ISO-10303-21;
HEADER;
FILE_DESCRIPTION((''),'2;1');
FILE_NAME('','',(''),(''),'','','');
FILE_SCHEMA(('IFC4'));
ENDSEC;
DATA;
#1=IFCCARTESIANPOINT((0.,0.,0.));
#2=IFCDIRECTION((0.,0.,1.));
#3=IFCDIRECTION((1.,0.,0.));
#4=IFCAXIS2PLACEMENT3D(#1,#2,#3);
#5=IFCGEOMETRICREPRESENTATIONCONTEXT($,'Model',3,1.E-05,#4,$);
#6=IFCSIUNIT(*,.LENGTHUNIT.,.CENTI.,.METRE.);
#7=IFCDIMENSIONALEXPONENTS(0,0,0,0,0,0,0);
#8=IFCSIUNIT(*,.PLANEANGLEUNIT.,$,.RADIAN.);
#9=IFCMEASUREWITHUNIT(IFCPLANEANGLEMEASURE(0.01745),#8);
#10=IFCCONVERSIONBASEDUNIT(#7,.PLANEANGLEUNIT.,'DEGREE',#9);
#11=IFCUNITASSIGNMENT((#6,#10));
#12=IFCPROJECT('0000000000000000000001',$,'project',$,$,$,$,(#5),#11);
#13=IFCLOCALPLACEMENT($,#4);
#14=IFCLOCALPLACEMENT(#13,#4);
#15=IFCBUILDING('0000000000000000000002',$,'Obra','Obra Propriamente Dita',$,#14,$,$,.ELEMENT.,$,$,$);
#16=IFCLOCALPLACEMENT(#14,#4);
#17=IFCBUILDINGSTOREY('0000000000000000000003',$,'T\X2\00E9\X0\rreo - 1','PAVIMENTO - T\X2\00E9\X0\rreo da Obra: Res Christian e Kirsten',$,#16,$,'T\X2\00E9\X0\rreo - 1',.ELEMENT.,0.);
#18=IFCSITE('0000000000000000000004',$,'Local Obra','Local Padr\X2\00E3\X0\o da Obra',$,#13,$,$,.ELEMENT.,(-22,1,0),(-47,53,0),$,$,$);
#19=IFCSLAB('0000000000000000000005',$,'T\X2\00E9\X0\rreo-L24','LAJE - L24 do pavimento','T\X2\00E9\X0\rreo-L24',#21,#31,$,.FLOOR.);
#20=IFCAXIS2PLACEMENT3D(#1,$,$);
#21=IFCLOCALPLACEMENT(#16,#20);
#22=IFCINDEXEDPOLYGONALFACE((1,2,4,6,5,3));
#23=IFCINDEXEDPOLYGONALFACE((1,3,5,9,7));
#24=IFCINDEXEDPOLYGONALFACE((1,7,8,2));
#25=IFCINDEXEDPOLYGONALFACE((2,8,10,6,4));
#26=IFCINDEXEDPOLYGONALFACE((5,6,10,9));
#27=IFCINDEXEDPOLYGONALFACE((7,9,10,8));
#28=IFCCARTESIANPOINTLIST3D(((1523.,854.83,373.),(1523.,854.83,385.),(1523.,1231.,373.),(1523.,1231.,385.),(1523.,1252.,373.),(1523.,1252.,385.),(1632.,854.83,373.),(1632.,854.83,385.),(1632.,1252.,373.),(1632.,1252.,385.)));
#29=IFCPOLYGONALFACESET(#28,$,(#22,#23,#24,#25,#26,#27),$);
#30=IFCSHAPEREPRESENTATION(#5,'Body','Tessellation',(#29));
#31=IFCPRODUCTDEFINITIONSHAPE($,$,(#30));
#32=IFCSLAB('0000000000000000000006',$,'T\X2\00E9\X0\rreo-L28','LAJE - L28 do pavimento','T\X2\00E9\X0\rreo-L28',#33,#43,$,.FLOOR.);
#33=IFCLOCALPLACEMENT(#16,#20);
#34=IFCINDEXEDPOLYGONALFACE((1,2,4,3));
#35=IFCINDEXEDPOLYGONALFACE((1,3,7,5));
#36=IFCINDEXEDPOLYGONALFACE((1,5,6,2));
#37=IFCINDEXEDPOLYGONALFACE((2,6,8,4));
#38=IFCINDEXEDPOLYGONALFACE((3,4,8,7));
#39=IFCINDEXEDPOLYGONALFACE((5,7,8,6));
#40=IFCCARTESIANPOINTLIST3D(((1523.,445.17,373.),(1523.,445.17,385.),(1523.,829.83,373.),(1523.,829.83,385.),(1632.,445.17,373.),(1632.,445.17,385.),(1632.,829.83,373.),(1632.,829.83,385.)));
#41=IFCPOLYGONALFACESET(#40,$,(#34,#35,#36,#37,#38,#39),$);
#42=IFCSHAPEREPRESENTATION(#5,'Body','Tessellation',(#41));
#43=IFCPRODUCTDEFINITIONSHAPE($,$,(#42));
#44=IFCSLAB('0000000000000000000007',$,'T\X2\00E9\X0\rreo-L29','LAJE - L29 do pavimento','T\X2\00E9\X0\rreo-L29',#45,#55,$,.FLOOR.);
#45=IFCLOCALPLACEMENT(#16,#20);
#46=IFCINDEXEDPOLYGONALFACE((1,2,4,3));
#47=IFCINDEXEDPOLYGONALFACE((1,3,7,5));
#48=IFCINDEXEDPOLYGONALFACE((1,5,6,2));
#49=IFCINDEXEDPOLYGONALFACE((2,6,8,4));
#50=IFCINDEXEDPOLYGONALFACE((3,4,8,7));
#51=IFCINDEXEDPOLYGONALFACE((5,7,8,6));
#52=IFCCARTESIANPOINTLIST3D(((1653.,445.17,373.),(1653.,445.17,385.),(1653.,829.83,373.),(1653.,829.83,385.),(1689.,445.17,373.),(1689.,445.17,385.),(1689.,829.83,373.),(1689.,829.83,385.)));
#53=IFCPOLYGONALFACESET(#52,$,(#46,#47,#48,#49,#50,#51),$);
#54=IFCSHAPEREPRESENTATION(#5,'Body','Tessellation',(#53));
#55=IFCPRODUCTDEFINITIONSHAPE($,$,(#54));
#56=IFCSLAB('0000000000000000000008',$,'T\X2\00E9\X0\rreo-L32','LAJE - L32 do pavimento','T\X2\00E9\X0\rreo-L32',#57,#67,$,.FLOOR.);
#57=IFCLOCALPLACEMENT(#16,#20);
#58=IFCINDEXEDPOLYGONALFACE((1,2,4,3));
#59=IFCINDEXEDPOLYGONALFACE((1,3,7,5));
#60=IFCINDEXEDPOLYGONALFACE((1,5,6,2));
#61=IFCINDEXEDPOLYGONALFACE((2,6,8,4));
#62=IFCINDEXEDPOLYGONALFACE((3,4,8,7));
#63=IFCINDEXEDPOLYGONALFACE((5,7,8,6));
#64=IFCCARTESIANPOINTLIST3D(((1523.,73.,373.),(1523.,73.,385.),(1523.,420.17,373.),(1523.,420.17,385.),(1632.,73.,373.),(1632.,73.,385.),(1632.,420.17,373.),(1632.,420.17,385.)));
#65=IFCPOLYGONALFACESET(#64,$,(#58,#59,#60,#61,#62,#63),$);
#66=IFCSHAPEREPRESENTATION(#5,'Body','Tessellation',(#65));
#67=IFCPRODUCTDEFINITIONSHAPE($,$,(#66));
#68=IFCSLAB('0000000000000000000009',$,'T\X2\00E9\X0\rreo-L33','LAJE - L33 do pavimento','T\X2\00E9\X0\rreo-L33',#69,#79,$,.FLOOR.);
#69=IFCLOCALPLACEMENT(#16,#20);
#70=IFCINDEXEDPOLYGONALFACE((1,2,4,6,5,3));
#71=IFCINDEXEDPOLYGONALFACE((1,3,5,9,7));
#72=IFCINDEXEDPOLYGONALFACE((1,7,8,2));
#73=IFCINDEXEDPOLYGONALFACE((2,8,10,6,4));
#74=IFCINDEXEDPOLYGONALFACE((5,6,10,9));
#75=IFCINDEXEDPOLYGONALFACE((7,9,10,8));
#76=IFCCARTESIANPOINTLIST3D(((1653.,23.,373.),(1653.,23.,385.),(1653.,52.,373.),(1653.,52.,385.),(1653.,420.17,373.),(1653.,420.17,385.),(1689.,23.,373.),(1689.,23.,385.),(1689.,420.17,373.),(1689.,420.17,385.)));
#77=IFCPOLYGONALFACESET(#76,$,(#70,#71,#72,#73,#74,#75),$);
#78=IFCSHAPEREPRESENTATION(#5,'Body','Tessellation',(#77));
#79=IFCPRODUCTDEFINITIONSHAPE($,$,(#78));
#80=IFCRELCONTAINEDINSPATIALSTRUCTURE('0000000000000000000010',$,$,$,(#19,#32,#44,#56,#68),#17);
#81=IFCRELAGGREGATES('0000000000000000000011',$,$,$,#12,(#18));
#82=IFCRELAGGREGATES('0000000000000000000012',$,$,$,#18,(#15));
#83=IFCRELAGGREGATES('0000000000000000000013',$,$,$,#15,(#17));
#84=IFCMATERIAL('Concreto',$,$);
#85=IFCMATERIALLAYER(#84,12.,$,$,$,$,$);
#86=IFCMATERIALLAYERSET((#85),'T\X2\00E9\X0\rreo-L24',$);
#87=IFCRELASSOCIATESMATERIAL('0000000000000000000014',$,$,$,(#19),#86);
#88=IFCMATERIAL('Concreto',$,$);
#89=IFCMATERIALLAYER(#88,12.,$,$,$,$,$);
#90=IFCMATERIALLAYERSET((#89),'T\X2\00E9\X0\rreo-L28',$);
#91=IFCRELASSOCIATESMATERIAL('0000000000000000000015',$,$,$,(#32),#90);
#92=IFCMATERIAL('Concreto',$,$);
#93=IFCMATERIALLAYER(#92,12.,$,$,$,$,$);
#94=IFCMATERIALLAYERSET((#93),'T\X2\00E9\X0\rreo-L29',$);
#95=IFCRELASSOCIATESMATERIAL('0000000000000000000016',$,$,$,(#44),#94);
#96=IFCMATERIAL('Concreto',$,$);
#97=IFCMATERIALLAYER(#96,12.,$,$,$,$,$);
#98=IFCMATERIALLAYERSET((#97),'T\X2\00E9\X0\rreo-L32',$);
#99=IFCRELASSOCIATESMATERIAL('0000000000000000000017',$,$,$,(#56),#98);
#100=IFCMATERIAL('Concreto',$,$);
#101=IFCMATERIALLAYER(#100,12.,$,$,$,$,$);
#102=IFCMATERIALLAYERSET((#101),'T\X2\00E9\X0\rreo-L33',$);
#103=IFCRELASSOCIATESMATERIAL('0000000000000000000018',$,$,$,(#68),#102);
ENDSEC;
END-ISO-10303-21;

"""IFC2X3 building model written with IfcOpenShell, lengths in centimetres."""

from ifc_helpers import new_model, entity, si_unit, converted_unit, frame, origin_with_axes, place, context, project, spatial, polyline, outline, extrude, material, layer, layer_set, layer_usage, element, save


model = new_model("IFC2X3")

# Units and contexts
model_context = context("Model", 3, precision=1e-05, world=origin_with_axes())
ifc_project = project(units=[si_unit("LENGTHUNIT", "METRE", prefix="CENTI"), converted_unit("PLANEANGLEUNIT", "DEGREE", entity("IfcPlaneAngleMeasure", 0.01745), si_unit("PLANEANGLEUNIT", "RADIAN"), dimensions=[0, 0, 0, 0, 0, 0, 0])], contexts=[model_context])

# Site, building, storey
site_placement = place(None, origin_with_axes())
site = spatial("IfcSite", under=ifc_project, at=site_placement, Name="Local Obra", Description="Local Padrão da Obra", CompositionType="ELEMENT", RefLatitude=(-22, 1, 0), RefLongitude=(-47, 53, 0))
building_placement = place(site_placement, origin_with_axes())
building = spatial("IfcBuilding", under=site, at=building_placement, Name="Obra", Description="Obra Propriamente Dita", CompositionType="ELEMENT")
storey_placement = place(building_placement, origin_with_axes())
storey = spatial("IfcBuildingStorey", under=building, at=storey_placement, Name="Térreo - 1", Description="PAVIMENTO - Térreo da Obra: Res Christian e Kirsten", LongName="Térreo - 1", CompositionType="ELEMENT", Elevation=0.0)

# Slabs
ifc_material_1 = material(Name="Concreto")
ifc_layer_1 = layer(ifc_material_1, 12.0)
ifc_layer_set_1 = layer_set([ifc_layer_1], Name="Térreo-L24")
ifc_layer_usage_1 = layer_usage(ifc_layer_set_1, "AXIS3", "POSITIVE", 0.0)
slab_1_placement = place(storey_placement, frame((1632.0, 854.83, 373.0), z_axis=(0.0, 0.0, 1.0), x_axis=(1.0, 0.0, 0.0)))
element("IfcSlab", 1, at=slab_1_placement, inside=storey, material=ifc_layer_usage_1, Name="Térreo-L24", Description="LAJE - L24 do pavimento", ObjectType="Térreo-L24", PredefinedType="FLOOR", context=model_context, shape_type="SweptSolid", body=[
    extrude(outline(polyline([(0.0, 397.17), (-109.0, 397.17), (-109.0, 376.17), (-109.0, 0.0), (0.0, 0.0), (0.0, 397.17)])), origin_with_axes(), (0.0, 0.0, 1.0), 12.0),
])
ifc_material_2 = material(Name="Concreto")
ifc_layer_2 = layer(ifc_material_2, 12.0)
ifc_layer_set_2 = layer_set([ifc_layer_2], Name="Térreo-L28")
ifc_layer_usage_2 = layer_usage(ifc_layer_set_2, "AXIS3", "POSITIVE", 0.0)
slab_2_placement = place(storey_placement, frame((1632.0, 445.17, 373.0), z_axis=(0.0, 0.0, 1.0), x_axis=(1.0, 0.0, 0.0)))
element("IfcSlab", 2, at=slab_2_placement, inside=storey, material=ifc_layer_usage_2, Name="Térreo-L28", Description="LAJE - L28 do pavimento", ObjectType="Térreo-L28", PredefinedType="FLOOR", context=model_context, shape_type="SweptSolid", body=[
    extrude(outline(polyline([(0.0, 384.66), (-109.0, 384.66), (-109.0, 0.0), (0.0, 0.0), (0.0, 384.66)])), origin_with_axes(), (0.0, 0.0, 1.0), 12.0),
])
ifc_material_3 = material(Name="Concreto")
ifc_layer_3 = layer(ifc_material_3, 12.0)
ifc_layer_set_3 = layer_set([ifc_layer_3], Name="Térreo-L29")
ifc_layer_usage_3 = layer_usage(ifc_layer_set_3, "AXIS3", "POSITIVE", 0.0)
slab_3_placement = place(storey_placement, frame((1689.0, 445.17, 373.0), z_axis=(0.0, 0.0, 1.0), x_axis=(1.0, 0.0, 0.0)))
element("IfcSlab", 3, at=slab_3_placement, inside=storey, material=ifc_layer_usage_3, Name="Térreo-L29", Description="LAJE - L29 do pavimento", ObjectType="Térreo-L29", PredefinedType="FLOOR", context=model_context, shape_type="SweptSolid", body=[
    extrude(outline(polyline([(0.0, 384.66), (-36.0, 384.66), (-36.0, 0.0), (0.0, 0.0), (0.0, 384.66)])), origin_with_axes(), (0.0, 0.0, 1.0), 12.0),
])
ifc_material_4 = material(Name="Concreto")
ifc_layer_4 = layer(ifc_material_4, 12.0)
ifc_layer_set_4 = layer_set([ifc_layer_4], Name="Térreo-L32")
ifc_layer_usage_4 = layer_usage(ifc_layer_set_4, "AXIS3", "POSITIVE", 0.0)
slab_4_placement = place(storey_placement, frame((1632.0, 73.0, 373.0), z_axis=(0.0, 0.0, 1.0), x_axis=(1.0, 0.0, 0.0)))
element("IfcSlab", 4, at=slab_4_placement, inside=storey, material=ifc_layer_usage_4, Name="Térreo-L32", Description="LAJE - L32 do pavimento", ObjectType="Térreo-L32", PredefinedType="FLOOR", context=model_context, shape_type="SweptSolid", body=[
    extrude(outline(polyline([(0.0, 347.17), (-109.0, 347.17), (-109.0, 0.0), (0.0, 0.0), (0.0, 347.17)])), origin_with_axes(), (0.0, 0.0, 1.0), 12.0),
])
ifc_material_5 = material(Name="Concreto")
ifc_layer_5 = layer(ifc_material_5, 12.0)
ifc_layer_set_5 = layer_set([ifc_layer_5], Name="Térreo-L33")
ifc_layer_usage_5 = layer_usage(ifc_layer_set_5, "AXIS3", "POSITIVE", 0.0)
slab_5_placement = place(storey_placement, frame((1653.0, 420.17, 373.0), z_axis=(0.0, 0.0, 1.0), x_axis=(1.0, 0.0, 0.0)))
element("IfcSlab", 5, at=slab_5_placement, inside=storey, material=ifc_layer_usage_5, Name="Térreo-L33", Description="LAJE - L33 do pavimento", ObjectType="Térreo-L33", PredefinedType="FLOOR", context=model_context, shape_type="SweptSolid", body=[
    extrude(outline(polyline([(0.0, -368.17), (0.0, -397.17), (36.0, -397.17), (36.0, 0.0), (0.0, 0.0), (0.0, -368.17)])), origin_with_axes(), (0.0, 0.0, 1.0), 12.0),
])

save(model, "model.ifc")
